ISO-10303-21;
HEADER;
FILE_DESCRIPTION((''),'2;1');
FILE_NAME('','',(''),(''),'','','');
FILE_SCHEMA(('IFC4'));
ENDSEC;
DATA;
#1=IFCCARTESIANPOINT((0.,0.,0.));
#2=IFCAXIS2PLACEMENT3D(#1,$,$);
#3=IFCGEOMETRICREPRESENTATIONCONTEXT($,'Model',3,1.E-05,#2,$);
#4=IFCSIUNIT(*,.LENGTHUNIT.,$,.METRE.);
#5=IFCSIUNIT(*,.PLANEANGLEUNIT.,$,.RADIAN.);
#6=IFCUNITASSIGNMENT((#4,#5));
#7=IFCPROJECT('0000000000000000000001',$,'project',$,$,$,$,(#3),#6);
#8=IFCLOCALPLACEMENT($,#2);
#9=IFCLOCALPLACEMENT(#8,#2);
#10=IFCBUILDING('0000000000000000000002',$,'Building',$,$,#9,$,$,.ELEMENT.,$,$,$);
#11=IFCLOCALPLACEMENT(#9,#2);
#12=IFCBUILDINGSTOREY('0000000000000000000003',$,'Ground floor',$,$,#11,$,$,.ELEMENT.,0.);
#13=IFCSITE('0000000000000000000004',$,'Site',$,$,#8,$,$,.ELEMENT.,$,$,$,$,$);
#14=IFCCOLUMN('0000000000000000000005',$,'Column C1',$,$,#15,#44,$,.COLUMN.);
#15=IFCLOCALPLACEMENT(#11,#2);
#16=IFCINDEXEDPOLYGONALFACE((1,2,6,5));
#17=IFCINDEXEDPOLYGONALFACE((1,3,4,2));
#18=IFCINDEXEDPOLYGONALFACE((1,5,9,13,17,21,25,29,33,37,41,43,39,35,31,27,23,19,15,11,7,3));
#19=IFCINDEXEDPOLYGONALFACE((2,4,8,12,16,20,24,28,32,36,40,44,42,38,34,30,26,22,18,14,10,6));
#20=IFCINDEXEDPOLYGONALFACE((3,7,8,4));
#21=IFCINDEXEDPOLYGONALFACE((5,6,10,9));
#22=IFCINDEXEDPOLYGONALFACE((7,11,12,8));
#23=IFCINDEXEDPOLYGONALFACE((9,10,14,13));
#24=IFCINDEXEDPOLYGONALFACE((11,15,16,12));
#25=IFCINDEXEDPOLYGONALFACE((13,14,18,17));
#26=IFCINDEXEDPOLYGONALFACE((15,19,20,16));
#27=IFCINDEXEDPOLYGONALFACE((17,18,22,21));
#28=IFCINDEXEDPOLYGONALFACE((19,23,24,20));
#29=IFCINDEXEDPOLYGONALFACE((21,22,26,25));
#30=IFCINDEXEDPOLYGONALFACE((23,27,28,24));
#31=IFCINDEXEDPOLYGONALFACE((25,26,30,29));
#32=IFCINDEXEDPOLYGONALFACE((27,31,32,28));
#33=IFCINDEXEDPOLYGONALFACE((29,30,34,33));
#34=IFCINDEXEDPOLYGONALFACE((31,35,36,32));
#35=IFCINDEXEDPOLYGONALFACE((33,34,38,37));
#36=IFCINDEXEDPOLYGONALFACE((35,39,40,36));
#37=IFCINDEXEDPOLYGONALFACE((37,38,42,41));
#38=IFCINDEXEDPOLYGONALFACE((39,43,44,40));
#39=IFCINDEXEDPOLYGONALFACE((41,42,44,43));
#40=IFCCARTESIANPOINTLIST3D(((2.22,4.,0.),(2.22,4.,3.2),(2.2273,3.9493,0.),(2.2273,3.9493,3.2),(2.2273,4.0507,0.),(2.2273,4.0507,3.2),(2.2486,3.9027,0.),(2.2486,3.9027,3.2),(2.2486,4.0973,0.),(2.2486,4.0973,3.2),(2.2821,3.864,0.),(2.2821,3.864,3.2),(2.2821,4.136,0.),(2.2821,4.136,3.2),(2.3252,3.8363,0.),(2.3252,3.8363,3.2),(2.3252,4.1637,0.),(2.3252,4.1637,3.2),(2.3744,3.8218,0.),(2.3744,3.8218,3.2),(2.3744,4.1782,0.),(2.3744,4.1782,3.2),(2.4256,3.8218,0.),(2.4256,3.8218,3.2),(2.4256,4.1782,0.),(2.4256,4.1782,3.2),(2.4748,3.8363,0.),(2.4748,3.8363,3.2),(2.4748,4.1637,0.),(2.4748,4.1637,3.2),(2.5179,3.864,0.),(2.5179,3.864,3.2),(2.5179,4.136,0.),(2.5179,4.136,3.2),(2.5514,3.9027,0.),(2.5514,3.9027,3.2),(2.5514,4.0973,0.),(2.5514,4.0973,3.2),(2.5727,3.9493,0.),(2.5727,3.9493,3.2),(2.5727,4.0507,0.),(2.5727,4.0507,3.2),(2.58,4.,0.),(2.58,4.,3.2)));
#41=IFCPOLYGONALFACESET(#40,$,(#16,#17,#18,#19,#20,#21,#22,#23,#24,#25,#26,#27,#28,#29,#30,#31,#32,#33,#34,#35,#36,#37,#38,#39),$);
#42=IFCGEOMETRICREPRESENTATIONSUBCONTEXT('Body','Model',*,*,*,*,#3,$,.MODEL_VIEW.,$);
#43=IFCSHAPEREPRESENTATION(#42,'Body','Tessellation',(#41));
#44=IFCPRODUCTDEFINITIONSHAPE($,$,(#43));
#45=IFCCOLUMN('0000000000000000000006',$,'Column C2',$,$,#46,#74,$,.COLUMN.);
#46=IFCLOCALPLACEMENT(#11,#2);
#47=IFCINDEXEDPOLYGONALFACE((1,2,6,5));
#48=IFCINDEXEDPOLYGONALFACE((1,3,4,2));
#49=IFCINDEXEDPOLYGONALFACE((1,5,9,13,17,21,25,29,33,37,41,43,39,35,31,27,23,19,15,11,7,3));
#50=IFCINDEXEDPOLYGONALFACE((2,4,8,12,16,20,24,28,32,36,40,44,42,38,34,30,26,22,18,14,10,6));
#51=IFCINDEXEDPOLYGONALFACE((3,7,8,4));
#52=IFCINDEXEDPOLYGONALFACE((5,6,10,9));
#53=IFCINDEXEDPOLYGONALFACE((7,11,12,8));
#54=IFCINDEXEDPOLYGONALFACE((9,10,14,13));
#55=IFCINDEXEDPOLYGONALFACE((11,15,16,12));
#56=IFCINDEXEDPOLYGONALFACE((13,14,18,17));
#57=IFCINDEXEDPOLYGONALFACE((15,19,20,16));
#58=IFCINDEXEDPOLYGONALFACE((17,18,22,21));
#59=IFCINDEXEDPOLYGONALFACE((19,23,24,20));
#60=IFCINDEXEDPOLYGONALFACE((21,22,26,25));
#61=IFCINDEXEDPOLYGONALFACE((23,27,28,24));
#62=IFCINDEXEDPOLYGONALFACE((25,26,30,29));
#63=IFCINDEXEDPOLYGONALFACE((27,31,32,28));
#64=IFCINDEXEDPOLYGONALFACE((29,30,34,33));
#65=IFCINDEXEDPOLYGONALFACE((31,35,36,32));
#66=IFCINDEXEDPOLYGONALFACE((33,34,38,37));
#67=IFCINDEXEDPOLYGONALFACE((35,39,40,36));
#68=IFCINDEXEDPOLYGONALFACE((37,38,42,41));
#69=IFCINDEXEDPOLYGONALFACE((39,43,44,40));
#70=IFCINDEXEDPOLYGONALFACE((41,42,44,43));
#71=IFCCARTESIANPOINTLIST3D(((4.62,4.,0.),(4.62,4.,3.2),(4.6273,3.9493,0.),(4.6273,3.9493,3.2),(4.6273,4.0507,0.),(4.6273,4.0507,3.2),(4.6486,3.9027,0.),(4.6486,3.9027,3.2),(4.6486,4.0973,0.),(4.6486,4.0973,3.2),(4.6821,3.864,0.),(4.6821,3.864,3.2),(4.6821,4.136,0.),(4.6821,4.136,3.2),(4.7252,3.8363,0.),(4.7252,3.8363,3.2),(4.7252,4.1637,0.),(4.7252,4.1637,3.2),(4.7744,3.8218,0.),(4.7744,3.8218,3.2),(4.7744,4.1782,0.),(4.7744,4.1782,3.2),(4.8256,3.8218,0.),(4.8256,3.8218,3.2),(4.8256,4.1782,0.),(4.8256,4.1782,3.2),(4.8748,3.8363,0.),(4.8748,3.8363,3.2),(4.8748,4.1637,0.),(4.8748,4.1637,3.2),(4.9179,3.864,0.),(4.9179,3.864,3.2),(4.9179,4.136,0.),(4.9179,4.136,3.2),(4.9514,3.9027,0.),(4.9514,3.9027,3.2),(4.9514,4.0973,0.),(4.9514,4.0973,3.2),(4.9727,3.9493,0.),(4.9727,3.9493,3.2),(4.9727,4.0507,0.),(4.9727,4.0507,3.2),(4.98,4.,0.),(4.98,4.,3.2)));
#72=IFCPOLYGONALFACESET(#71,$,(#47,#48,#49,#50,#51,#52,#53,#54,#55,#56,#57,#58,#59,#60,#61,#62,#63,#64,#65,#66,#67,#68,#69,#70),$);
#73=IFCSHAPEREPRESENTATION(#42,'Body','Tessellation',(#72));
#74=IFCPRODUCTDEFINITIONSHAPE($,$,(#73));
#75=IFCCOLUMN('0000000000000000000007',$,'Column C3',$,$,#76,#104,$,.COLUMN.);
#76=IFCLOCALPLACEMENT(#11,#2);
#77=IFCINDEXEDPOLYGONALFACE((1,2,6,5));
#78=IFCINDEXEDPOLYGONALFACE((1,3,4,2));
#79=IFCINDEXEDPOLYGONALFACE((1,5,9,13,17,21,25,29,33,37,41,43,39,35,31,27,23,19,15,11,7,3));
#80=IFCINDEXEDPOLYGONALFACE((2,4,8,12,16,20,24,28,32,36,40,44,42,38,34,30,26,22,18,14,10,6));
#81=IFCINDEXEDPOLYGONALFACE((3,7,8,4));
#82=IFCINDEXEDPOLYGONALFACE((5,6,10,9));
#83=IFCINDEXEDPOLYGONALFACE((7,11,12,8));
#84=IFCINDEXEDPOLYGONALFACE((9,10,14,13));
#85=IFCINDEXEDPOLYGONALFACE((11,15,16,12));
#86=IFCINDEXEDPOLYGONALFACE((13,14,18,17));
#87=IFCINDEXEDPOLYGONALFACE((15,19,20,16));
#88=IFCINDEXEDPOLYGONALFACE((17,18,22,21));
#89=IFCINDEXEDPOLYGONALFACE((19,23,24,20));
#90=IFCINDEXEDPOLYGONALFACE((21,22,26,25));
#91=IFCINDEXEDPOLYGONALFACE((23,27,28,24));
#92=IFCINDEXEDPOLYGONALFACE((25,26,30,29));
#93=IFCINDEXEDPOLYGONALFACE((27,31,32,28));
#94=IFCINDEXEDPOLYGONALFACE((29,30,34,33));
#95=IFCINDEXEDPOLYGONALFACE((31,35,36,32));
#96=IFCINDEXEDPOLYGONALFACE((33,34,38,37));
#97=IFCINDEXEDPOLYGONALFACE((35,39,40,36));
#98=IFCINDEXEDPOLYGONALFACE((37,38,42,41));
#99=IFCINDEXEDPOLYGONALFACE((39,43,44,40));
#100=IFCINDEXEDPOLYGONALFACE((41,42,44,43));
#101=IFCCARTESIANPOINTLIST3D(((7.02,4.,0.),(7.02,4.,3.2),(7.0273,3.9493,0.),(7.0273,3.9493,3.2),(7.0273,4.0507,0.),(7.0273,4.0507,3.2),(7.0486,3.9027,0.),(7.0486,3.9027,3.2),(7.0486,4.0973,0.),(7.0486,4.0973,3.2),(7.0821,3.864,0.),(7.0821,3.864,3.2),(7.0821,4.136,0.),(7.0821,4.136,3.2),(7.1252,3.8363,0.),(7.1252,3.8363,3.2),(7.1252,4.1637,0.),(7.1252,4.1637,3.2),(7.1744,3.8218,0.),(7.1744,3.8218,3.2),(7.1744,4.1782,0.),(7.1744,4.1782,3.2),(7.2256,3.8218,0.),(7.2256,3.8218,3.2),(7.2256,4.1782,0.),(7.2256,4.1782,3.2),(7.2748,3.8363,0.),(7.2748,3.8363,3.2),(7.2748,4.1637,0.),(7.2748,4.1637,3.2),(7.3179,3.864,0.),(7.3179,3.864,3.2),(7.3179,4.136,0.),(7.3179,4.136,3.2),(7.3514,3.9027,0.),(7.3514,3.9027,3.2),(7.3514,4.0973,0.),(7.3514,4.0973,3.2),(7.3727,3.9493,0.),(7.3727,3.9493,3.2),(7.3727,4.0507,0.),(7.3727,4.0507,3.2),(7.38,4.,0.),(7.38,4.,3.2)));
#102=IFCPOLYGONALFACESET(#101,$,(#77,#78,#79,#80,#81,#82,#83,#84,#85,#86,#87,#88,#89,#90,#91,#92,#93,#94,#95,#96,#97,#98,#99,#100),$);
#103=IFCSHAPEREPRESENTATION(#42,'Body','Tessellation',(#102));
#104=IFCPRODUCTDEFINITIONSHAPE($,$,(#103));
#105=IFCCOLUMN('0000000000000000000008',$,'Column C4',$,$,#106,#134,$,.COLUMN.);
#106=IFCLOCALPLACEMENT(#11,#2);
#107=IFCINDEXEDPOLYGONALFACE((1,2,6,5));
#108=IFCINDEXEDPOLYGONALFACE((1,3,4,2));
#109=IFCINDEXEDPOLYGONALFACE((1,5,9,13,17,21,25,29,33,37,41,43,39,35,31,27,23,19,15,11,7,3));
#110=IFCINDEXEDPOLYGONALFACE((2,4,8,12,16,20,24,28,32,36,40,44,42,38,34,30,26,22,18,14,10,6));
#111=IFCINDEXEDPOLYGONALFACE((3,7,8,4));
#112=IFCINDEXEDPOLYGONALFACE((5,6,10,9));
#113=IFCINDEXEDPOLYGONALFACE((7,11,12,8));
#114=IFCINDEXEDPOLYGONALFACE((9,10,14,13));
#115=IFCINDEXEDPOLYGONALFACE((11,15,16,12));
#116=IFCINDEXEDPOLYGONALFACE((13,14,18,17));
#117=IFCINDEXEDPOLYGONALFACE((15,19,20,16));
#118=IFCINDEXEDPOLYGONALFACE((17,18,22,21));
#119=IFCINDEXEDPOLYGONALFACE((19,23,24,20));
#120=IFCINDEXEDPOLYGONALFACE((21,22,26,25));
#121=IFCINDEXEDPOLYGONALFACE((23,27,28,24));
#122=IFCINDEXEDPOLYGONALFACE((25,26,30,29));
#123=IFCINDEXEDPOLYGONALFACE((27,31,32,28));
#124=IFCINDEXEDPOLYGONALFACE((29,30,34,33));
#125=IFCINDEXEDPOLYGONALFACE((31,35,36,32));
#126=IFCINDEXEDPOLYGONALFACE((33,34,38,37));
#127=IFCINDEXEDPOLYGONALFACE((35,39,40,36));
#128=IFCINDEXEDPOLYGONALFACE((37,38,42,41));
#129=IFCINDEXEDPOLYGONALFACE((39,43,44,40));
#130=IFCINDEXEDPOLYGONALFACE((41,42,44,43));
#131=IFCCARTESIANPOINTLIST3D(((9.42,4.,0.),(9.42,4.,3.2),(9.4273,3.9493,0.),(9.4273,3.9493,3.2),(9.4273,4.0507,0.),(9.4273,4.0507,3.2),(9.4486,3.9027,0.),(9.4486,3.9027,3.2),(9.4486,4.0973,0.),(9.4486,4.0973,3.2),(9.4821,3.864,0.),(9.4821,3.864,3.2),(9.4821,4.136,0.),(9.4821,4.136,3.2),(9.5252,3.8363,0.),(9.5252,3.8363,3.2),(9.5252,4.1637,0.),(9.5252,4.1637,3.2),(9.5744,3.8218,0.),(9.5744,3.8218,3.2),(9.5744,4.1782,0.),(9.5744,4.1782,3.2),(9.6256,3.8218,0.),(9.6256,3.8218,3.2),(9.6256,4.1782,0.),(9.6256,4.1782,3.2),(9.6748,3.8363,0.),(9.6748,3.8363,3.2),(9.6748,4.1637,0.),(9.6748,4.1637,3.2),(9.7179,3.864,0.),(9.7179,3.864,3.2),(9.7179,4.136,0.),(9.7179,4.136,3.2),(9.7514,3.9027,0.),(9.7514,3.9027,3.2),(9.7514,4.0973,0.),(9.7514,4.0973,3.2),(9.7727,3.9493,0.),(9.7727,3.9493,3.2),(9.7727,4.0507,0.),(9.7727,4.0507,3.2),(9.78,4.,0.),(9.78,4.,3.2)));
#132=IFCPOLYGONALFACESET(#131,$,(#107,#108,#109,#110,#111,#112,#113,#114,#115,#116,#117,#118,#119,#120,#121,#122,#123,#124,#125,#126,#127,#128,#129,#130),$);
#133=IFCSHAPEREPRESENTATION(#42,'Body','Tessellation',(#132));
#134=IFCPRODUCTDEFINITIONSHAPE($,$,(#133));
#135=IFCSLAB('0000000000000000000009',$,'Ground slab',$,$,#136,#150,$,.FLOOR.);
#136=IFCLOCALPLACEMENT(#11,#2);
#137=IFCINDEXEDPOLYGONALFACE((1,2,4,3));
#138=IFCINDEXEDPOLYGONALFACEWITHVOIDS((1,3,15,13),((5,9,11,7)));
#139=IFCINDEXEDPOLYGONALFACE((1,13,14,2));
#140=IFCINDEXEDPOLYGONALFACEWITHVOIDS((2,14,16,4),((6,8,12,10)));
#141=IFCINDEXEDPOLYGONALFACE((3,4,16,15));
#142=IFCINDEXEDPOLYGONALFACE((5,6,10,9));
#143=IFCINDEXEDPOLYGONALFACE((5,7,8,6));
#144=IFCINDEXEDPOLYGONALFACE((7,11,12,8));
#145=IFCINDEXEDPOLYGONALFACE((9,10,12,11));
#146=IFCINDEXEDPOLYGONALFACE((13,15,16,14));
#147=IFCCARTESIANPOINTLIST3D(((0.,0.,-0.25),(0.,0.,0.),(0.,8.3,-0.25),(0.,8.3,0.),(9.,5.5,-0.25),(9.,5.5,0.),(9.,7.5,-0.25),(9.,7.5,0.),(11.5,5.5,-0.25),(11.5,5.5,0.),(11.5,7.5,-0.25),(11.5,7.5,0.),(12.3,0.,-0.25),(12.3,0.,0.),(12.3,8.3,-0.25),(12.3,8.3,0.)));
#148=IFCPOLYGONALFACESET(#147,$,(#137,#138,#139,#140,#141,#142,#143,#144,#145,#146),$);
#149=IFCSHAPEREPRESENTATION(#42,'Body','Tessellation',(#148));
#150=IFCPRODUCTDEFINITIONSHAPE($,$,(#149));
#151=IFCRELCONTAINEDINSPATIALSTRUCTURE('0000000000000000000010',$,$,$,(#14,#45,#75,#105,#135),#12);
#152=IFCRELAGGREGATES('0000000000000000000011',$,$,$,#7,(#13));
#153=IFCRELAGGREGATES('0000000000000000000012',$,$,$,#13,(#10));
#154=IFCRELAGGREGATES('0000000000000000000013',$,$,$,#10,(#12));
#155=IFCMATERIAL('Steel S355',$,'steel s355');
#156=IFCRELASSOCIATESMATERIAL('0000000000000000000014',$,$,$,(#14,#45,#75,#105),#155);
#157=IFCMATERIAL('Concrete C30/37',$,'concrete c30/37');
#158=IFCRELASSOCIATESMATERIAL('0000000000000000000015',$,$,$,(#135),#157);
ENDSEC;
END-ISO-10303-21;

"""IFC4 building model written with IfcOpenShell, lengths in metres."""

from ifc_helpers import new_model, si_unit, frame, origin, origin_2d, place, context, subcontext, project, spatial, polyline, circle, outline, extrude, source, transform, mapped, material, element, save


model = new_model("IFC4")

# Units and contexts
model_context = context("Model", 3, precision=1e-05, world=origin())
body_context = subcontext(model_context, "Body", "Model", "MODEL_VIEW")
ifc_project = project(units=[si_unit("LENGTHUNIT", "METRE"), si_unit("PLANEANGLEUNIT", "RADIAN")], contexts=[model_context])

# Site, building, storey
site_placement = place(None, origin())
site = spatial("IfcSite", under=ifc_project, at=site_placement, Name="Site", CompositionType="ELEMENT")
building_placement = place(site_placement, origin())
building = spatial("IfcBuilding", under=site, at=building_placement, Name="Building", CompositionType="ELEMENT")
storey_placement = place(building_placement, origin())
storey = spatial("IfcBuildingStorey", under=building, at=storey_placement, Name="Ground floor", CompositionType="ELEMENT", Elevation=0.0)

# Columns
ifc_material_1 = material(Name="Steel S355", Category="steel s355")
shared_shape_1 = source(origin(), body_context, "Body", "SweptSolid", [
    extrude(circle(Radius=0.18, at=origin_2d()), origin(), (0.0, 0.0, 1.0), 3.2),
])
for number, where, name in (
    (1, (2.4, 4.0, 0.0), "Column C1"),
    (2, (4.8, 4.0, 0.0), "Column C2"),
    (3, (7.2, 4.0, 0.0), "Column C3"),
    (4, (9.6, 4.0, 0.0), "Column C4"),
):
    element("IfcColumn", number, at=place(storey_placement, frame(where)), inside=storey, material=ifc_material_1, Name=name, PredefinedType="COLUMN", context=body_context, shape_type="MappedRepresentation", body=[
        mapped(shared_shape_1, transform((0.0, 0.0, 0.0))),
    ])

# Slab
ifc_material_2 = material(Name="Concrete C30/37", Category="concrete c30/37")
slab_placement = place(storey_placement, origin())
element("IfcSlab", 5, at=slab_placement, inside=storey, material=ifc_material_2, Name="Ground slab", PredefinedType="FLOOR", context=body_context, shape_type="SweptSolid", body=[
    extrude(outline(polyline([(0.0, 0.0), (12.3, 0.0), (12.3, 8.3), (0.0, 8.3), (0.0, 0.0)]), holes=[polyline([(9.0, 5.5), (11.5, 5.5), (11.5, 7.5), (9.0, 7.5), (9.0, 5.5)])]), frame((0.0, 0.0, -0.25)), (0.0, 0.0, 1.0), 0.25),
])

save(model, "model.ifc")
